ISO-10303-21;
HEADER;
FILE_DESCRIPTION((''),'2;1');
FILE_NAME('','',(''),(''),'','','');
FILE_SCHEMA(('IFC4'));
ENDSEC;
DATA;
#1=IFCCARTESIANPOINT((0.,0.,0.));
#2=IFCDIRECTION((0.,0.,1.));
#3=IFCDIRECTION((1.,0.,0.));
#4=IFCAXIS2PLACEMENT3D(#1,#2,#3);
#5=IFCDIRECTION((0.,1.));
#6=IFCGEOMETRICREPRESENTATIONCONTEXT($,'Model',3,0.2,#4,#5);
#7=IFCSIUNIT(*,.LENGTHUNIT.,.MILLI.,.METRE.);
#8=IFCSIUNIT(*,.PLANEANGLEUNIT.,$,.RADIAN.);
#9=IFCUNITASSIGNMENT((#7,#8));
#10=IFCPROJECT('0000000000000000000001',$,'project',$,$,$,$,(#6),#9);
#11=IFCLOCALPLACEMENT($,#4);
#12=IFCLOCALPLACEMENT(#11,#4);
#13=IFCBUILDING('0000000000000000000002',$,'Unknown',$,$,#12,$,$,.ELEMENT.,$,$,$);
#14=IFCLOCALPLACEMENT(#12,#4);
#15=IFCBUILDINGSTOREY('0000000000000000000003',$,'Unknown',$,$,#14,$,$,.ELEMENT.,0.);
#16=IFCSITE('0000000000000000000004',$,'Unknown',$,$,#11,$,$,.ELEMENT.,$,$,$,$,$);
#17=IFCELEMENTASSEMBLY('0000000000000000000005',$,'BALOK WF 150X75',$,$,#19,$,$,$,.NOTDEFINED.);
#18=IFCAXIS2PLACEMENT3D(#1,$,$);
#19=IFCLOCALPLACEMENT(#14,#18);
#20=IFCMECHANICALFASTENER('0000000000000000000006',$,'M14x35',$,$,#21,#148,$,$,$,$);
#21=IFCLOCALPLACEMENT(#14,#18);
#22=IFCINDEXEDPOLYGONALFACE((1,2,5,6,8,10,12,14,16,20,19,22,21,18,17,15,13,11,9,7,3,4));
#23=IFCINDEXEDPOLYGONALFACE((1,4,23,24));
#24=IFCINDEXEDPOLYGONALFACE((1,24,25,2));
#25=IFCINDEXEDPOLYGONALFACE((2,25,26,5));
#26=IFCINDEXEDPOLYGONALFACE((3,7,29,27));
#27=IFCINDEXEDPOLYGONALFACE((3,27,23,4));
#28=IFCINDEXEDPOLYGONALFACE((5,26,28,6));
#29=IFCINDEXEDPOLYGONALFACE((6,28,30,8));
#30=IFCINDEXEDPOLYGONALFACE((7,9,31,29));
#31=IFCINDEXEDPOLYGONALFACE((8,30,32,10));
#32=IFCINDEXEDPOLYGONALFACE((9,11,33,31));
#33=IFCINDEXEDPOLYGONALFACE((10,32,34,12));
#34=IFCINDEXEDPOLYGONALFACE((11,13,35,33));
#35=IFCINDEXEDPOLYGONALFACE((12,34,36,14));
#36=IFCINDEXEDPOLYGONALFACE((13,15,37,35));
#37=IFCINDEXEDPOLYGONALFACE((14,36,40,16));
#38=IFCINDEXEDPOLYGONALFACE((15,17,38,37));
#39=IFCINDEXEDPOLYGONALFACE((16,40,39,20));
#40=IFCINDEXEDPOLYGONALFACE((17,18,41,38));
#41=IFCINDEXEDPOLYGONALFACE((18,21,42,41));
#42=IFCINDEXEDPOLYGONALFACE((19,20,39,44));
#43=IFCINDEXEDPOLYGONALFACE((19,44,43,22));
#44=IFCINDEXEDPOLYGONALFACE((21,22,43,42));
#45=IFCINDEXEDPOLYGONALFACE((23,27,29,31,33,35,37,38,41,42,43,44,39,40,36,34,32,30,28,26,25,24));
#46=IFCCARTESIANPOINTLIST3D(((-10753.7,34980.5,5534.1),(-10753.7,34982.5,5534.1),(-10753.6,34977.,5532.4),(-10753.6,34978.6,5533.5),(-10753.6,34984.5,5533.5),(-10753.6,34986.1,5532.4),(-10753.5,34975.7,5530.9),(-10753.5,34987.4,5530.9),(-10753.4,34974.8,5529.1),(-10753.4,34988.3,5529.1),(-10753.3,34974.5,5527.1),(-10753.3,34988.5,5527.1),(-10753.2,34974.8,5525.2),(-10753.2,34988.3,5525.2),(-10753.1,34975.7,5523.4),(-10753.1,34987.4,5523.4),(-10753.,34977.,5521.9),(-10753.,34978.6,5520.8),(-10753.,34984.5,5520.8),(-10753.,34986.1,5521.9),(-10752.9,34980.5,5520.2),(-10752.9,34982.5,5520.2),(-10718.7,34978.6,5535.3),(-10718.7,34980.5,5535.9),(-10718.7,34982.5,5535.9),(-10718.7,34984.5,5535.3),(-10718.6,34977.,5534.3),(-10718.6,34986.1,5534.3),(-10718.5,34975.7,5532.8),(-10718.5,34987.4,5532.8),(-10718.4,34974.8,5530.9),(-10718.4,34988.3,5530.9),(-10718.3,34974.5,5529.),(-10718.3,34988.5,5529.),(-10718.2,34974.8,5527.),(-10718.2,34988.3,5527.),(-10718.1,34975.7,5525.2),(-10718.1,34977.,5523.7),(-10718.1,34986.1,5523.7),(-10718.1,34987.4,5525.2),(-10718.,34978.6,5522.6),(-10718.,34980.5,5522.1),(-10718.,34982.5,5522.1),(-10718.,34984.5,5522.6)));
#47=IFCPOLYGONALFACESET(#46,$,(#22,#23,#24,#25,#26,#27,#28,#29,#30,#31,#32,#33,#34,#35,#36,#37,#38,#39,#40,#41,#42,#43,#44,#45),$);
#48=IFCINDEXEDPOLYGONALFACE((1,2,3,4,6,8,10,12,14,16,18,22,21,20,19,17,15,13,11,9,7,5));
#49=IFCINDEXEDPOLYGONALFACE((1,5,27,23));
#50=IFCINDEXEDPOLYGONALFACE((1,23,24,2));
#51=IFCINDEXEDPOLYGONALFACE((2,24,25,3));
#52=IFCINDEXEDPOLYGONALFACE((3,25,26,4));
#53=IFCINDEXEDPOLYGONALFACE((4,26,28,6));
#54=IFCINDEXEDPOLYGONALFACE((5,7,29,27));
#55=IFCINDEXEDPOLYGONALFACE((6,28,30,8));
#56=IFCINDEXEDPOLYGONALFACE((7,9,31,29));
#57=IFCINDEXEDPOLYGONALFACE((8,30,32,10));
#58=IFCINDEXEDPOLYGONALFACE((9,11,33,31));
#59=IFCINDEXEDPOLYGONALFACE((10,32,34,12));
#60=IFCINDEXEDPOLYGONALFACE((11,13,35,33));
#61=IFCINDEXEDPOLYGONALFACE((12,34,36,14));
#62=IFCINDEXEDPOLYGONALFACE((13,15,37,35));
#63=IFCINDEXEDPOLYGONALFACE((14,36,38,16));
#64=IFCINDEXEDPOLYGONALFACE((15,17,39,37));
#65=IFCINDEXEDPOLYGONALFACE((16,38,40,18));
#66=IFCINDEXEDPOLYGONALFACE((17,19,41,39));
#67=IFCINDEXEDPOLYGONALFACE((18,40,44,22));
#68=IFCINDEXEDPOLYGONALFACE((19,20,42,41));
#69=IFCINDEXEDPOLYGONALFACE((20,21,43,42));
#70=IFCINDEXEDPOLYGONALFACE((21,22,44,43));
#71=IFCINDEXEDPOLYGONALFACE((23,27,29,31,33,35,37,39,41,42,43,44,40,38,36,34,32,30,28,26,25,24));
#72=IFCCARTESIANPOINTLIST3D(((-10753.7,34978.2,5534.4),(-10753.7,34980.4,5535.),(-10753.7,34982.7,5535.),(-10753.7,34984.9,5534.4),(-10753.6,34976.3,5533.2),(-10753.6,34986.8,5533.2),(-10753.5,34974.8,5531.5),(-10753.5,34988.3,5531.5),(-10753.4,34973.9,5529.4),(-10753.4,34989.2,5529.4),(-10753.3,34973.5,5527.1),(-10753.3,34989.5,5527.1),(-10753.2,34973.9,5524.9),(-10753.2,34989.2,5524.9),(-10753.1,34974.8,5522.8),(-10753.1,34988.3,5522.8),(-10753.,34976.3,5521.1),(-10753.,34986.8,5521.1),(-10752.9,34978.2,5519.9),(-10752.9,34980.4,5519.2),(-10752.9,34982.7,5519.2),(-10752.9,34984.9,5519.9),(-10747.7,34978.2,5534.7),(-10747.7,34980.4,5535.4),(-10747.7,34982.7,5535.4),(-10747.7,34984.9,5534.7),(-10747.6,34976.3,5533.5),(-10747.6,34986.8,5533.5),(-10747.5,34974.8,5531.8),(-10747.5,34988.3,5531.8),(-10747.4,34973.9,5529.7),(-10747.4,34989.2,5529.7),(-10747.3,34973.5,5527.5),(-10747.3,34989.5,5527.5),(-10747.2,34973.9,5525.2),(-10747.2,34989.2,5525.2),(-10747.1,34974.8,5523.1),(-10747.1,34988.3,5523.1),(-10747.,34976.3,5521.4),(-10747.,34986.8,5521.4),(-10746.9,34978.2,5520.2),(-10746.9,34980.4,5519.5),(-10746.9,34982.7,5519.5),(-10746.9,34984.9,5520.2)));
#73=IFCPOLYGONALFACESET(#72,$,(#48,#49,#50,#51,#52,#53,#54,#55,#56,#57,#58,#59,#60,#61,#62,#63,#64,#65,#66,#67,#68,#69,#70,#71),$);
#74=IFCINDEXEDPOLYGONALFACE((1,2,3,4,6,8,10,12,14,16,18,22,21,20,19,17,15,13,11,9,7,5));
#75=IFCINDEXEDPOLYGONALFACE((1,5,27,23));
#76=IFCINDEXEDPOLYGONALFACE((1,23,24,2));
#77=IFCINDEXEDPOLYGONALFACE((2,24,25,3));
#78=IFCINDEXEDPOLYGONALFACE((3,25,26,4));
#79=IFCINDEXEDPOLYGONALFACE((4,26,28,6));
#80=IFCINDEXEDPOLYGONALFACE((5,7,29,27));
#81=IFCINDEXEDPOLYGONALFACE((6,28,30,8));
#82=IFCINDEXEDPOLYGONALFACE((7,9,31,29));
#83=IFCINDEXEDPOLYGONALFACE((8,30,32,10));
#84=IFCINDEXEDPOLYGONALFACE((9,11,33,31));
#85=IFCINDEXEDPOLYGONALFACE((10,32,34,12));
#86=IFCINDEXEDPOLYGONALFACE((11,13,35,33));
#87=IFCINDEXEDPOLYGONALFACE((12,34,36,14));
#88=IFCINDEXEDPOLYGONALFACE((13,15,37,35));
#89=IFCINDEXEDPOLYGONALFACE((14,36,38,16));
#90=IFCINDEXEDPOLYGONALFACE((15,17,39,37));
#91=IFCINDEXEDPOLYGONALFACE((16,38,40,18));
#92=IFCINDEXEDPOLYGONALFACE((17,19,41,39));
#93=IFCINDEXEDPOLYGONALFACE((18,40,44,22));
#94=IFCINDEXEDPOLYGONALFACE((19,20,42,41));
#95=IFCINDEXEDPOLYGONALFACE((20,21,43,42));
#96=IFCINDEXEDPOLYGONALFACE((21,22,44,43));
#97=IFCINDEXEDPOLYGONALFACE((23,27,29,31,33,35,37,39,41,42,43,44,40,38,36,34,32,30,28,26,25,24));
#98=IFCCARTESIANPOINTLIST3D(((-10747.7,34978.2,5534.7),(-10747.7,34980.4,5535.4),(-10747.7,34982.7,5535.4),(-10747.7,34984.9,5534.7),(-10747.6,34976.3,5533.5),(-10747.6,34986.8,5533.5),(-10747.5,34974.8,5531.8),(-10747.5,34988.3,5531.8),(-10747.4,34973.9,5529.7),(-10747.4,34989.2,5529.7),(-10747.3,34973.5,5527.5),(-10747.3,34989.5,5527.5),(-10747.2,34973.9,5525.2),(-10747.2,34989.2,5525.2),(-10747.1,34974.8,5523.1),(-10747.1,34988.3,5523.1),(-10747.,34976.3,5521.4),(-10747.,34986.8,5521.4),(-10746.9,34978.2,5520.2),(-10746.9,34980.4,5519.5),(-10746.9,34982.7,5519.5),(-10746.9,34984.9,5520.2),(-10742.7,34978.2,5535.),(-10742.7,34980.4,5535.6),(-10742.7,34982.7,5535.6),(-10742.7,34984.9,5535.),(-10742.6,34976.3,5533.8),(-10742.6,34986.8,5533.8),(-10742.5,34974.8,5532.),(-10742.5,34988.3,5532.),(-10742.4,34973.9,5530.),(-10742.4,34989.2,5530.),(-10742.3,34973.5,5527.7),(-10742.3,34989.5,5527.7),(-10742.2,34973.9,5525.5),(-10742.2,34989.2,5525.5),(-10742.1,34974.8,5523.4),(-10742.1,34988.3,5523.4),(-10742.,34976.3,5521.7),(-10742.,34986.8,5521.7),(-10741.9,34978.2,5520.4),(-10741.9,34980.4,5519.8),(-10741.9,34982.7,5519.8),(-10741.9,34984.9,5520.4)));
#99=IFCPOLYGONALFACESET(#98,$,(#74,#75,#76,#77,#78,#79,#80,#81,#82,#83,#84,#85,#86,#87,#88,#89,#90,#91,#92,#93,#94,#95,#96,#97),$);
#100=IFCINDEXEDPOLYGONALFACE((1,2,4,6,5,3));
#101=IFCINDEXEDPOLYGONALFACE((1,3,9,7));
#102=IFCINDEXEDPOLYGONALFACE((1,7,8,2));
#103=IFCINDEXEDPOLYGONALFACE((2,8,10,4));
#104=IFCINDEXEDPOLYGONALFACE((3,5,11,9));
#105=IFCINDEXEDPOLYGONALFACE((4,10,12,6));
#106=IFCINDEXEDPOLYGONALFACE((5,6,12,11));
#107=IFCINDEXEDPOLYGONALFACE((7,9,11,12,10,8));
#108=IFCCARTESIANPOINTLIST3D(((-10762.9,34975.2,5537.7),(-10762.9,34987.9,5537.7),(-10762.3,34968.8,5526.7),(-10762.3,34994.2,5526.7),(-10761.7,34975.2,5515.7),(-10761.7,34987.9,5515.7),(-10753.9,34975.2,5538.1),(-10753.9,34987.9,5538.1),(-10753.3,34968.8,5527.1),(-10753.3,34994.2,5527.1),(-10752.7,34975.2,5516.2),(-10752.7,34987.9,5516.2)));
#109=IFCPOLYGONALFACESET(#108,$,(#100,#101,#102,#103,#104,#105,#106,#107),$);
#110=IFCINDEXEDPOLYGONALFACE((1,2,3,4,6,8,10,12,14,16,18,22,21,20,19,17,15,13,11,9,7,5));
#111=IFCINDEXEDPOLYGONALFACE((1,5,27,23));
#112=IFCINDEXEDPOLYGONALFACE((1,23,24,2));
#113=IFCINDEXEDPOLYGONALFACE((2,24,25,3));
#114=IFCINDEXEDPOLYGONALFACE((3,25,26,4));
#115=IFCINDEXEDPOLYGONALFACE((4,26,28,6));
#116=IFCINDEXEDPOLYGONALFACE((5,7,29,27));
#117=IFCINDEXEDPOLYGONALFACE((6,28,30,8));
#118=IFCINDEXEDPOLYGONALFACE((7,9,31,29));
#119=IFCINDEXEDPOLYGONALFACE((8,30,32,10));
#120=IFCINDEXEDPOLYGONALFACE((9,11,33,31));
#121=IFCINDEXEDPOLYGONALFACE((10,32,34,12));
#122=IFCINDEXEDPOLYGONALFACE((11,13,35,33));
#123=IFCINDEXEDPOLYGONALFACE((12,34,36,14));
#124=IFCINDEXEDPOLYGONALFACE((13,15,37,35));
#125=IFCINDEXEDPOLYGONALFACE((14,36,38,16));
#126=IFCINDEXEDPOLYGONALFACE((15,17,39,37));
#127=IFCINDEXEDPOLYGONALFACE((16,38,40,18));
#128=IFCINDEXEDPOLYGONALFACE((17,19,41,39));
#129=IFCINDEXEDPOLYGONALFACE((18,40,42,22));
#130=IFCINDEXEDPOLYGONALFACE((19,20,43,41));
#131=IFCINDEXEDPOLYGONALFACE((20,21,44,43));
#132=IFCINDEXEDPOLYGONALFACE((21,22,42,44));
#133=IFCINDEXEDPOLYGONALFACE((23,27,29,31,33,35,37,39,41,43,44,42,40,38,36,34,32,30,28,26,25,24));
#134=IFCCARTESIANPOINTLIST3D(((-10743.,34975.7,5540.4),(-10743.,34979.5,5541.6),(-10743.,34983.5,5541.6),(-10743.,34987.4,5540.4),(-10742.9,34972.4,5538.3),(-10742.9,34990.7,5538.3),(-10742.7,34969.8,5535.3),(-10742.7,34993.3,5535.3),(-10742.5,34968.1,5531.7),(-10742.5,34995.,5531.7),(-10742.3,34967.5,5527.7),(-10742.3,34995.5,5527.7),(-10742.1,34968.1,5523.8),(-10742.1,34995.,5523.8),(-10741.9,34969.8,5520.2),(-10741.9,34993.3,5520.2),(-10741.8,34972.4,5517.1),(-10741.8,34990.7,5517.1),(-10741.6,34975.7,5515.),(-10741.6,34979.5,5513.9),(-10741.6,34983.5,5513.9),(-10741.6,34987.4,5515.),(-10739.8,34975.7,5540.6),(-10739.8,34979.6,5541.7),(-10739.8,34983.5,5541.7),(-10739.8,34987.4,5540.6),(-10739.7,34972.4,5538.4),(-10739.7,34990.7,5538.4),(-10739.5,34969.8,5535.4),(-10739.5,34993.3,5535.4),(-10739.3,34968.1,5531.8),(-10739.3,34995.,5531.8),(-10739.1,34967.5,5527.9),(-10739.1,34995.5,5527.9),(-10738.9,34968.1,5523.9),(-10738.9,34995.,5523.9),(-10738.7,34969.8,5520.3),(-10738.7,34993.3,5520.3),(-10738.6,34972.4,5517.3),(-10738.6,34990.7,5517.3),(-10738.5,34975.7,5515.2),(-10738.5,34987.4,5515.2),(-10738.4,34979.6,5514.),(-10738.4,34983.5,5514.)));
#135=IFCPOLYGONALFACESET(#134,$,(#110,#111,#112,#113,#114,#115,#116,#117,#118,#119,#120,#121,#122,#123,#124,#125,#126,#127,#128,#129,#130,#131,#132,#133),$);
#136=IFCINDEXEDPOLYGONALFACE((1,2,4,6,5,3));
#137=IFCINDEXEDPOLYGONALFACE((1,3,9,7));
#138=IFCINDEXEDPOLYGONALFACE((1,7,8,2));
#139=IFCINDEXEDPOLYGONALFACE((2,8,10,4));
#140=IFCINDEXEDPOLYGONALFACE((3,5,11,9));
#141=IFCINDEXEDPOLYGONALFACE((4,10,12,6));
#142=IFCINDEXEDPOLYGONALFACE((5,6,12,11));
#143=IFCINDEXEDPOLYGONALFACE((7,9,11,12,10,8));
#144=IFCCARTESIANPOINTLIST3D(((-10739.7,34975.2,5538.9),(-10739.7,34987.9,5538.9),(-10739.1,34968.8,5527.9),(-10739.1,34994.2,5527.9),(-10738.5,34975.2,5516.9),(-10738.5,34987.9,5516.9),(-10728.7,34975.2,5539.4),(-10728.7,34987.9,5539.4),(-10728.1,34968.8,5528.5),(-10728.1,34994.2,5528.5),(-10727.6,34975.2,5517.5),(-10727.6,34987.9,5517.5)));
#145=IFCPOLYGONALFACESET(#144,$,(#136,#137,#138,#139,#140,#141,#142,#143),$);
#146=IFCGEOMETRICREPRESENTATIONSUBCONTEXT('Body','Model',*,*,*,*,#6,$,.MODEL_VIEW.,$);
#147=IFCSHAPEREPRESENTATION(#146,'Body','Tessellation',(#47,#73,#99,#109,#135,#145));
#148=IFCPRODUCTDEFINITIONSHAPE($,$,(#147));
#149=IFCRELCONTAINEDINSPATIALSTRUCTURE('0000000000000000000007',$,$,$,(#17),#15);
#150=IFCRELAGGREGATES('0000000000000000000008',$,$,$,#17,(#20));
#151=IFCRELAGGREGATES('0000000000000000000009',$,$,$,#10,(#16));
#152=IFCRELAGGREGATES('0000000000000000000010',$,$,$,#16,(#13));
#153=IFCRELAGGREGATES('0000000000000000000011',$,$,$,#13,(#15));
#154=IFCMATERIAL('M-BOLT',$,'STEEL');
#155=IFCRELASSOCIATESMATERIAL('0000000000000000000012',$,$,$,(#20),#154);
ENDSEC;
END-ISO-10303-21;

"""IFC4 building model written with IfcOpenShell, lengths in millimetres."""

from ifc_helpers import new_model, si_unit, direction, frame, origin_with_axes, place, context, subcontext, project, spatial, line, arc, indexed_curve, outline, extrude, source, transform, mapped, material, element, aggregate, save


model = new_model("IFC4")

# Units and contexts
model_context = context("Model", 3, precision=0.2, world=origin_with_axes(), true_north=direction((0.0, 1.0)))
body_context = subcontext(model_context, "Body", "Model", "MODEL_VIEW")
ifc_project = project(units=[si_unit("LENGTHUNIT", "METRE", prefix="MILLI"), si_unit("PLANEANGLEUNIT", "RADIAN")], contexts=[model_context])

# Site, building, storey
site_placement = place(None, origin_with_axes())
site = spatial("IfcSite", under=ifc_project, at=site_placement, Name="Unknown", CompositionType="ELEMENT")
building_placement = place(site_placement, origin_with_axes())
building = spatial("IfcBuilding", under=site, at=building_placement, Name="Unknown", CompositionType="ELEMENT")
storey_placement = place(building_placement, origin_with_axes())
storey = spatial("IfcBuildingStorey", under=building, at=storey_placement, Name="Unknown", CompositionType="ELEMENT", Elevation=0.0)

# Shared definitions
ifc_material_1 = material(Name="M-BOLT", Category="STEEL")

# Element assembly
assembly_1_placement = place(storey_placement, frame((-10746.1, 35225.4, 5552.5), z_axis=(-0.99863, 0.0, -0.052336), x_axis=(0.0, -1.0, 0.0)))
assembly_1 = element("IfcElementAssembly", 1, at=assembly_1_placement, inside=storey, Name="BALOK WF 150X75", PredefinedType="NOTDEFINED")

# Mechanical fastener
shared_shape_1 = source(origin_with_axes(), body_context, "Body", "SweptSolid", [
    extrude(outline(indexed_curve([(7.0, 0.0), (0.0, 7.0), (-7.0, 0.0), (0.0, -7.0)], segments=[arc(1, 2, 3), arc(3, 4, 1)])), frame((0.0, 0.0, -2.6), z_axis=(0.0, 0.0, -1.0), x_axis=(0.0, 1.0, 0.0)), (0.0, 0.0, 1.0), 35.0),
    extrude(outline(indexed_curve([(8.0, 0.0), (0.0, 8.0), (-8.0, 0.0), (0.0, -8.0)], segments=[arc(1, 2, 3), arc(3, 4, 1)])), frame((0.0, 0.0, -2.6), z_axis=(0.0, 0.0, -1.0), x_axis=(0.0, 1.0, 0.0)), (0.0, 0.0, 1.0), 6.0),
    extrude(outline(indexed_curve([(8.0, 0.0), (0.0, 8.0), (-8.0, 0.0), (0.0, -8.0)], segments=[arc(1, 2, 3), arc(3, 4, 1)])), frame((0.0, 0.0, -8.6), z_axis=(0.0, 0.0, -1.0), x_axis=(0.0, 1.0, 0.0)), (0.0, 0.0, 1.0), 5.0),
    extrude(outline(indexed_curve([(12.7, 0.0), (6.4, 11.0), (-6.4, 11.0), (-12.7, 0.0), (-6.4, -11.0), (6.4, -11.0)], segments=[line(1, 2, 3, 4, 5, 6, 1)])), frame((0.0, 0.0, 6.4), z_axis=(0.0, 0.0, -1.0), x_axis=(0.0, 1.0, 0.0)), (0.0, 0.0, 1.0), 9.0),
    extrude(outline(indexed_curve([(14.0, 0.0), (0.0, 14.0), (-14.0, 0.0), (0.0, -14.0)], segments=[arc(1, 2, 3), arc(3, 4, 1)])), frame((0.0, 0.0, -13.6), z_axis=(0.0, 0.0, -1.0), x_axis=(0.0, 1.0, 0.0)), (0.0, 0.0, 1.0), 3.2),
    extrude(outline(indexed_curve([(12.7, 0.0), (6.4, 11.0), (-6.4, 11.0), (-12.7, 0.0), (-6.4, -11.0), (6.4, -11.0)], segments=[line(1, 2, 3, 4, 5, 6, 1)])), frame((0.0, 0.0, -16.8), z_axis=(0.0, 0.0, -1.0), x_axis=(0.0, 1.0, 0.0)), (0.0, 0.0, 1.0), 11.0),
])
mechanical_fastener_1_placement = place(assembly_1_placement, frame((243.9, -24.9, 11.1), z_axis=(0.000006, 0.0, 1.0), x_axis=(0.0, -1.0, 0.0)))
mechanical_fastener_1 = element("IfcMechanicalFastener", 2, at=mechanical_fastener_1_placement, material=ifc_material_1, Name="M14x35", context=body_context, shape_type="MappedRepresentation", body=[
    mapped(shared_shape_1, transform((0.0, 0.0, 0.0))),
])
aggregate(assembly_1, [mechanical_fastener_1])

save(model, "model.ifc")
